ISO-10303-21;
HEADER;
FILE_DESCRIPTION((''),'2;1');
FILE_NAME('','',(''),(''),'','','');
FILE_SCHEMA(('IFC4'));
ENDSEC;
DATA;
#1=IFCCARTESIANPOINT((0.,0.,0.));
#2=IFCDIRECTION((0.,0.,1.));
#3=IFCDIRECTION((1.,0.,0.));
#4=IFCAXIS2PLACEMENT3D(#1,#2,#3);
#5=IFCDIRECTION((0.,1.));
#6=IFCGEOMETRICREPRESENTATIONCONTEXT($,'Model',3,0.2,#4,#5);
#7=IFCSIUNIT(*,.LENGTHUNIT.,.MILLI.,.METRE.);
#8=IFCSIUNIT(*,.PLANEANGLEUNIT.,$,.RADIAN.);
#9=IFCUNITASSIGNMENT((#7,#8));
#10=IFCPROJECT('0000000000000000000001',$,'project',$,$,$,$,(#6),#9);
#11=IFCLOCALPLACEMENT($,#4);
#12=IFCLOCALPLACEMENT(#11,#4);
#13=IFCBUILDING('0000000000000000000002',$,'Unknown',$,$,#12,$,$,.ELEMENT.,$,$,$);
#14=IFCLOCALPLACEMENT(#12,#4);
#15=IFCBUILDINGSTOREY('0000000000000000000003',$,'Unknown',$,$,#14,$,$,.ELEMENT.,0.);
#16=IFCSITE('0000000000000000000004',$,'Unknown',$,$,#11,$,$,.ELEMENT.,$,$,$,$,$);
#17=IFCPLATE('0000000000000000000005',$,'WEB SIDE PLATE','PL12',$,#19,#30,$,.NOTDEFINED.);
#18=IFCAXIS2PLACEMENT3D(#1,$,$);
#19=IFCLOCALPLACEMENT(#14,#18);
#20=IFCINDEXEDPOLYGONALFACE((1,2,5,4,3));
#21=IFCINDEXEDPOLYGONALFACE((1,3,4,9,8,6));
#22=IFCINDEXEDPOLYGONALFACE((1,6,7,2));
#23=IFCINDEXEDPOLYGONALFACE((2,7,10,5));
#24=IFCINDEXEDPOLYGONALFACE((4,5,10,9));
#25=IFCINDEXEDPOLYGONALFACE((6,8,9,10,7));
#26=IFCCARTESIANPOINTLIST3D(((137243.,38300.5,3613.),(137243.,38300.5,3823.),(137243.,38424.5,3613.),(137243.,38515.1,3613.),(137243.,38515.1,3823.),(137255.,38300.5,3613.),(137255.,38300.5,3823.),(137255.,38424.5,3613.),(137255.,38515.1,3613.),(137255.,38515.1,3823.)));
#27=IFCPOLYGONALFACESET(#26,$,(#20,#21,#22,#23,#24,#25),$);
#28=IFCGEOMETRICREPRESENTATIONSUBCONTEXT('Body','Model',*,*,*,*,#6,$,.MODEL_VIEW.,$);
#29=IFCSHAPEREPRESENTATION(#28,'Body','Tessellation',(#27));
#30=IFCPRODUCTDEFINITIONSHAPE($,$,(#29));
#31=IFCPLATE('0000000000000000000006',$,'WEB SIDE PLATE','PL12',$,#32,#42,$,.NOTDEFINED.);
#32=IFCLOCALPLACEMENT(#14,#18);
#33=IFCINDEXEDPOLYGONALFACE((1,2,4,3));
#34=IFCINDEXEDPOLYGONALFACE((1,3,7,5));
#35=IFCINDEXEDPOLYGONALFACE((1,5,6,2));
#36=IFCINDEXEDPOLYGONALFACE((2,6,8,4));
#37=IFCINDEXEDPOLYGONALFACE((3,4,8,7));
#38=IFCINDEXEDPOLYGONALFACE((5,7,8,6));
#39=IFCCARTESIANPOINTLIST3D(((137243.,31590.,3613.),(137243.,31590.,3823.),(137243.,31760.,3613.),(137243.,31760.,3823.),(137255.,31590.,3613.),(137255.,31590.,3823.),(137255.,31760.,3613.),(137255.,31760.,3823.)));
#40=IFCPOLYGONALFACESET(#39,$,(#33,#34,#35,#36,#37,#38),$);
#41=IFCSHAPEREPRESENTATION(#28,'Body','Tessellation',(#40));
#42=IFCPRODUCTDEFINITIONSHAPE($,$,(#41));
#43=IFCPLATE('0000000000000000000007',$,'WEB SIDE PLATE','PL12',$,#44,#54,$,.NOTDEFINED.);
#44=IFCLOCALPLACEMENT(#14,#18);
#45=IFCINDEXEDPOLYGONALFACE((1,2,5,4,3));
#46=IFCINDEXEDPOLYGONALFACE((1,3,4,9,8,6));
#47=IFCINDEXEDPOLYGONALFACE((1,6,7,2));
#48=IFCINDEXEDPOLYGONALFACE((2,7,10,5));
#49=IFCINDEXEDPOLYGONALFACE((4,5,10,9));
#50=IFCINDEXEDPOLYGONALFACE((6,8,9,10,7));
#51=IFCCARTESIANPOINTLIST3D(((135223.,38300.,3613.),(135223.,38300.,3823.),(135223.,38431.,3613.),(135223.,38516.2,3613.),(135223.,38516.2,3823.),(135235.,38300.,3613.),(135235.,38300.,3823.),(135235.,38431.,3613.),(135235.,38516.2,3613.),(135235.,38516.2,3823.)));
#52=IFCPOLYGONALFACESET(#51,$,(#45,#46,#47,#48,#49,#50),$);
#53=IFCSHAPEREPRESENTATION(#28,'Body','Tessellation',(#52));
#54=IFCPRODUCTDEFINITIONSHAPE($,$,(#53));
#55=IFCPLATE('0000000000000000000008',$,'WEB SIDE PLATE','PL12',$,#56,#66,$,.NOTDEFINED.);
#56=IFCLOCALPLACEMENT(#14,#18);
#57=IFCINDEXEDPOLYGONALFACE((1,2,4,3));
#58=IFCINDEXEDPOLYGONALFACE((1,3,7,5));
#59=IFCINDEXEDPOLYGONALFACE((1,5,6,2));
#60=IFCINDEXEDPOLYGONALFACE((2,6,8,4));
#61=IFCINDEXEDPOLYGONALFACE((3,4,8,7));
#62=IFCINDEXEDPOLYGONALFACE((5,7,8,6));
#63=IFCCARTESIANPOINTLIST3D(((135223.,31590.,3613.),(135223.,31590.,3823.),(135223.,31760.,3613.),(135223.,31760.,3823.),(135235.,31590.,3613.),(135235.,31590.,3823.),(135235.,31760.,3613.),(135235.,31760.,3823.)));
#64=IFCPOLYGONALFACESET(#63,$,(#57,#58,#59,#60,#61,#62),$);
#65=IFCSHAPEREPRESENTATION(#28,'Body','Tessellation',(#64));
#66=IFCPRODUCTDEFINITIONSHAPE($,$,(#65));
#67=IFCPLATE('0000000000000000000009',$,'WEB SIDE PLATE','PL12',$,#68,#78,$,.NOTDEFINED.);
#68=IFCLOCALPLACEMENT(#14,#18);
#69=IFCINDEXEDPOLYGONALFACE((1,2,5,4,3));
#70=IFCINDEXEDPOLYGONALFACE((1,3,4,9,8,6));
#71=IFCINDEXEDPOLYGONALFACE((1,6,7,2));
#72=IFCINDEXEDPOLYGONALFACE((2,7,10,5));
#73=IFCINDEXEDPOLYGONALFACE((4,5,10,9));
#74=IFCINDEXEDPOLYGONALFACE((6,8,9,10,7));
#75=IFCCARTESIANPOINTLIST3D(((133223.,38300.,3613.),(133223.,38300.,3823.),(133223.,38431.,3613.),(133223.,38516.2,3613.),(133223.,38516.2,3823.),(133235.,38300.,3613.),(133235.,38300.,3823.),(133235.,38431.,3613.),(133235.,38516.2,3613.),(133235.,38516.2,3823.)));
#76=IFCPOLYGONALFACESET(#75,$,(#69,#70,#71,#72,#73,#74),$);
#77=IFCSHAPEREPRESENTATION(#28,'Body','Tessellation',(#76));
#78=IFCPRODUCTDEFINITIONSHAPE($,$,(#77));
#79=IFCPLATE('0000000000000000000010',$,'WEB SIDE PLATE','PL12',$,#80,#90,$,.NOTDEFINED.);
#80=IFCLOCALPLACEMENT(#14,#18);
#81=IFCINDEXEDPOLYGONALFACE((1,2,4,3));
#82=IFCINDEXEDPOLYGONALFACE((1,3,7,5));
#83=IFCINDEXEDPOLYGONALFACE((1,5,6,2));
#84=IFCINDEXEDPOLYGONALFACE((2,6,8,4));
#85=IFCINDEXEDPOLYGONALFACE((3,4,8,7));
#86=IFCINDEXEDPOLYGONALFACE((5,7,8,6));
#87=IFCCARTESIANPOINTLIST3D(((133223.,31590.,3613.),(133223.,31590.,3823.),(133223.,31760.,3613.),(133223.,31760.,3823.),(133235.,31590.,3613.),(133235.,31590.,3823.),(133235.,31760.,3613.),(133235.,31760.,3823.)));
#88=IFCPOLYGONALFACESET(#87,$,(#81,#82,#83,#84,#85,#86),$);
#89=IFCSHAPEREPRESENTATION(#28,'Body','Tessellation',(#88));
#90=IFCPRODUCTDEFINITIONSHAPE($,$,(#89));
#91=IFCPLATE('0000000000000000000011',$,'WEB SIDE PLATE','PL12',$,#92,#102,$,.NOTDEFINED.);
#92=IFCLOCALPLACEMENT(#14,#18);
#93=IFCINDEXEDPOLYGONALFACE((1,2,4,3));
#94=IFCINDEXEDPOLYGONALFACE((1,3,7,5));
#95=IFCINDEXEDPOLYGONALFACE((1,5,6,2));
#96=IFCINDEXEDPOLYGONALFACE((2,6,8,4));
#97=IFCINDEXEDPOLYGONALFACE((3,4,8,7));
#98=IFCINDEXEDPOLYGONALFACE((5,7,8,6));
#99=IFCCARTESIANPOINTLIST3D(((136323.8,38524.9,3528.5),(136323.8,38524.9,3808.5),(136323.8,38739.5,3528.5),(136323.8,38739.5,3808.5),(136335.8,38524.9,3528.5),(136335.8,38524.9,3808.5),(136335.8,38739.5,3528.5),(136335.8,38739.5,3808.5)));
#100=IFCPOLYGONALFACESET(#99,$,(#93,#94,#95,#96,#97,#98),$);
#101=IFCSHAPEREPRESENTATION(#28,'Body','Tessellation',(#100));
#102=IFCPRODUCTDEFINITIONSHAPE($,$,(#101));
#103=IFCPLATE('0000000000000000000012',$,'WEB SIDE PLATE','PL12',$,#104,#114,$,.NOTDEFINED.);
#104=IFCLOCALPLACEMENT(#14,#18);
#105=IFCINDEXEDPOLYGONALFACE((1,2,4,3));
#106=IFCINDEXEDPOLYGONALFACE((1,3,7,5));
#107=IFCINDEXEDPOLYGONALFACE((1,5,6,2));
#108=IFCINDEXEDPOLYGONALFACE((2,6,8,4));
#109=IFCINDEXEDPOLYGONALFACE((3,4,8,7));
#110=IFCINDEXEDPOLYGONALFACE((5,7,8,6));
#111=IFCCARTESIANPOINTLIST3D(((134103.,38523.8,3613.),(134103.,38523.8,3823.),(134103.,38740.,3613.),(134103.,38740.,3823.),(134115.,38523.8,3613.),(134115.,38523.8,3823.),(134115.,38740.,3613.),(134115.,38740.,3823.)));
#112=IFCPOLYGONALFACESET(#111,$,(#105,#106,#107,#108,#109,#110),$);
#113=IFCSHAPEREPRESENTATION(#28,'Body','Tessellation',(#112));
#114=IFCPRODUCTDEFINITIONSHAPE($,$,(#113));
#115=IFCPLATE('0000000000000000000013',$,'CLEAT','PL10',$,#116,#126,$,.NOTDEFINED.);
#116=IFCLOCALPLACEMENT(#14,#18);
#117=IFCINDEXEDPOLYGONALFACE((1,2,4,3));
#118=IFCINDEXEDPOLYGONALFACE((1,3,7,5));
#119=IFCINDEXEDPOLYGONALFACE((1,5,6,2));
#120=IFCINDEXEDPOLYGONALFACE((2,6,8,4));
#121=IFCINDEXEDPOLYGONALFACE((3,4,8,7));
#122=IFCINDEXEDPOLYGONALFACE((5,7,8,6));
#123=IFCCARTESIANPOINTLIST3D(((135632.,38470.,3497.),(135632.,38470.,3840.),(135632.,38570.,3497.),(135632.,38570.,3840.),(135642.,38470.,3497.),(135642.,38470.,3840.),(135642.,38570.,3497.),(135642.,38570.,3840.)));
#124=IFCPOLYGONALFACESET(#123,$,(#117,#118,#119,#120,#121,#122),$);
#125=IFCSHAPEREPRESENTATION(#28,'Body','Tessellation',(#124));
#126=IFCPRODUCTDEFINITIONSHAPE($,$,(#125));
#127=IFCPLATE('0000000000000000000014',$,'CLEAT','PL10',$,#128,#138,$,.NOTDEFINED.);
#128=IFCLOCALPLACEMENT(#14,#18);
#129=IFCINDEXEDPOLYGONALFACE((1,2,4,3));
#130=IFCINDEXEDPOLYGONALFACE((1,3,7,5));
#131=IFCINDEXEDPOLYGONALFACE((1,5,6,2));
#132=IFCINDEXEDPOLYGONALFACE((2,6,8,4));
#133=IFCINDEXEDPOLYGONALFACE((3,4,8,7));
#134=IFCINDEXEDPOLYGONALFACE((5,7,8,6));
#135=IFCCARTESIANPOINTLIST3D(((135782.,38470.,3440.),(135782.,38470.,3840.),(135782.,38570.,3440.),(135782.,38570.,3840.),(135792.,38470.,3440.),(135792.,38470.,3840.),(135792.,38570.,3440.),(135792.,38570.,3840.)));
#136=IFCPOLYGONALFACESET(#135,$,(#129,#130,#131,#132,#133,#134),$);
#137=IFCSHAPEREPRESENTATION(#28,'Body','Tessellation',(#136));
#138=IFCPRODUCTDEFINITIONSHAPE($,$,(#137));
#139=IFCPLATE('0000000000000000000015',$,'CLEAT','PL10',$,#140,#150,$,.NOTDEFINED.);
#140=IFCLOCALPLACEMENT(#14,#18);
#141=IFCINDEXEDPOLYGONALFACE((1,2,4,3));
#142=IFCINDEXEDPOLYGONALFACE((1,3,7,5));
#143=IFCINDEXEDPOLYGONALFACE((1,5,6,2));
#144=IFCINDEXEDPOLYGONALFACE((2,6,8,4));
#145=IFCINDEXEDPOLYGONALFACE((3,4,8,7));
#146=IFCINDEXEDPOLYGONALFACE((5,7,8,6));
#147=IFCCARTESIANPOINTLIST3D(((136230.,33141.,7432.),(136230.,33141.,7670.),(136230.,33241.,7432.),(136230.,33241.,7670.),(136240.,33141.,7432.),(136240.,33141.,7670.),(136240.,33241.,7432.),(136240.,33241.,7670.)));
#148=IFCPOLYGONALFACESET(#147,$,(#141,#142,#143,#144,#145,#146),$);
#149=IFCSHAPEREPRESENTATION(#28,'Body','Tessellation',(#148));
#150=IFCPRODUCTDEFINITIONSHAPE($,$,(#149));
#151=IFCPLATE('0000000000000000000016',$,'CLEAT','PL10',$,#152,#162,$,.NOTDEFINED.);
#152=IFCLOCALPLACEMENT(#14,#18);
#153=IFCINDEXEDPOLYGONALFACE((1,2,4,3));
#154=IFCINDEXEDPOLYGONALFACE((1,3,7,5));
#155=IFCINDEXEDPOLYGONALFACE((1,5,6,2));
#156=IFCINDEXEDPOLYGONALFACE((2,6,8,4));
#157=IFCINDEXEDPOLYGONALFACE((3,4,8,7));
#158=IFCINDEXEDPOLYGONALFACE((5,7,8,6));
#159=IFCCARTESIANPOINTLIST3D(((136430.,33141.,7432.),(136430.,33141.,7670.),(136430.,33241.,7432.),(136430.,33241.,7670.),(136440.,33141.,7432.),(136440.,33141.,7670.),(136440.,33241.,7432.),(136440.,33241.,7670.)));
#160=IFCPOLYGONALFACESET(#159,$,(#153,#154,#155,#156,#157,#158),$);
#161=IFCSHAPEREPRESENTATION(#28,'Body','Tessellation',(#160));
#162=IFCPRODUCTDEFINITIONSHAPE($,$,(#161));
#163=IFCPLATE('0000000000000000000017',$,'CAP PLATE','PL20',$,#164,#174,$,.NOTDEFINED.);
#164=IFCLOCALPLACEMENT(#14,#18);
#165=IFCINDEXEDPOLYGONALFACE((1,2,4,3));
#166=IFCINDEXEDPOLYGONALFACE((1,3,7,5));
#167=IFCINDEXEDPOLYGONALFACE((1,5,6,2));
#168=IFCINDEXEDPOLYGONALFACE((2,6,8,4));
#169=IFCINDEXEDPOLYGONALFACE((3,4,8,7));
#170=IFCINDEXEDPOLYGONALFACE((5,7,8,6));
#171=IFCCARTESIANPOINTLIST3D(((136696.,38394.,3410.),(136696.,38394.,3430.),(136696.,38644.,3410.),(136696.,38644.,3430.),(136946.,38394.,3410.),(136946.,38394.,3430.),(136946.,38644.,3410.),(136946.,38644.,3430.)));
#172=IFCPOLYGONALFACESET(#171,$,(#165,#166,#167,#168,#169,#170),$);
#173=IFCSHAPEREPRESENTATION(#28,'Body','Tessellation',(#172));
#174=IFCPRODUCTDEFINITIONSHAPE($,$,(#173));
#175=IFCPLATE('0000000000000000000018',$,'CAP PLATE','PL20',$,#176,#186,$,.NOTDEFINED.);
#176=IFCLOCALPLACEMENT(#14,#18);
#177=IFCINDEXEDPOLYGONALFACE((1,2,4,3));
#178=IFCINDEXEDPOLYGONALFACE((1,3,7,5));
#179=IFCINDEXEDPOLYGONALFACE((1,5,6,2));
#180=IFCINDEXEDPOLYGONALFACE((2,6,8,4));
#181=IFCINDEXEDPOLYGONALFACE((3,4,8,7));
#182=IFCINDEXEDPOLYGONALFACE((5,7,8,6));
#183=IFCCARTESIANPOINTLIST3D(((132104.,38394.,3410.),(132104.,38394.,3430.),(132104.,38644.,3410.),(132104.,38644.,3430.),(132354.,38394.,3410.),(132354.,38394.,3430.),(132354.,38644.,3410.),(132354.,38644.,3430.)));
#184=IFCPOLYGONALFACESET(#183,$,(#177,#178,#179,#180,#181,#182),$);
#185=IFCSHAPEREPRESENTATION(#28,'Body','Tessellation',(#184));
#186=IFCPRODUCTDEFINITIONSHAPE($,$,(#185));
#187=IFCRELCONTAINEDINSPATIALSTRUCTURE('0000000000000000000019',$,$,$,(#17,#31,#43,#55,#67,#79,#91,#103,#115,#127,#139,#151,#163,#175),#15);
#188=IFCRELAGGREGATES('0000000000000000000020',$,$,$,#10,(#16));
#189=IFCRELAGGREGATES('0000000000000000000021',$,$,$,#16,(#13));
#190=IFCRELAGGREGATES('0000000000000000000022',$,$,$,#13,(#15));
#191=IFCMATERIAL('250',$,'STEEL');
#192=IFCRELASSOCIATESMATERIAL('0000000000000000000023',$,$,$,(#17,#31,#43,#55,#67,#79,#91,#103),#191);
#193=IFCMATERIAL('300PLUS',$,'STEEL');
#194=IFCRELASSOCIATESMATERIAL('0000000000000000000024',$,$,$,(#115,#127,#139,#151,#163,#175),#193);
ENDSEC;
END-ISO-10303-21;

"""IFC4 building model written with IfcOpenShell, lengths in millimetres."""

from ifc_helpers import new_model, si_unit, direction, frame, origin_with_axes, place, context, subcontext, project, spatial, line, indexed_curve, outline, extrude, material, element, save


model = new_model("IFC4")

# Units and contexts
model_context = context("Model", 3, precision=0.2, world=origin_with_axes(), true_north=direction((0.0, 1.0)))
body_context = subcontext(model_context, "Body", "Model", "MODEL_VIEW")
ifc_project = project(units=[si_unit("LENGTHUNIT", "METRE", prefix="MILLI"), si_unit("PLANEANGLEUNIT", "RADIAN")], contexts=[model_context])

# Site, building, storey
site_placement = place(None, origin_with_axes())
site = spatial("IfcSite", under=ifc_project, at=site_placement, Name="Unknown", CompositionType="ELEMENT")
building_placement = place(site_placement, origin_with_axes())
building = spatial("IfcBuilding", under=site, at=building_placement, Name="Unknown", CompositionType="ELEMENT")
storey_placement = place(building_placement, origin_with_axes())
storey = spatial("IfcBuildingStorey", under=building, at=storey_placement, Name="Unknown", CompositionType="ELEMENT", Elevation=0.0)

# Shared definitions
ifc_material_1 = material(Name="300PLUS", Category="STEEL")

# Plates
ifc_material_2 = material(Name="250", Category="STEEL")
plate_1_placement = place(storey_placement, frame((137249.0, 38424.5, 3613.0), z_axis=(1.0, 0.0, 0.0), x_axis=(0.0, 1.0, 0.0)))
element("IfcPlate", 1, at=plate_1_placement, inside=storey, material=ifc_material_2, Name="WEB SIDE PLATE", Description="PL12", PredefinedType="NOTDEFINED", context=body_context, shape_type="SolidModel", body=[
    extrude(outline(indexed_curve([(0.0, 0.0), (90.6, 0.0), (90.6, 210.0), (-124.0, 210.0), (-124.0, 0.0)], segments=[line(1, 2, 3, 4, 5, 1)])), frame((0.0, 0.0, 6.0), z_axis=(0.0, 0.0, 1.0), x_axis=(1.0, 0.0, 0.0)), (0.0, 0.0, -1.0), 12.0),
])
plate_2_placement = place(storey_placement, frame((137249.0, 31590.0, 3613.0), z_axis=(1.0, 0.0, 0.0), x_axis=(0.0, 1.0, 0.0)))
element("IfcPlate", 2, at=plate_2_placement, inside=storey, material=ifc_material_2, Name="WEB SIDE PLATE", Description="PL12", PredefinedType="NOTDEFINED", context=body_context, shape_type="SolidModel", body=[
    extrude(outline(indexed_curve([(0.0, 0.0), (170.0, 0.0), (170.0, 210.0), (0.0, 210.0)], segments=[line(1, 2, 3, 4, 1)])), frame((0.0, 0.0, 6.0), z_axis=(0.0, 0.0, 1.0), x_axis=(1.0, 0.0, 0.0)), (0.0, 0.0, -1.0), 12.0),
])
plate_3_placement = place(storey_placement, frame((135229.0, 38431.0, 3613.0), z_axis=(1.0, 0.0, 0.0), x_axis=(0.0, 1.0, 0.0)))
element("IfcPlate", 3, at=plate_3_placement, inside=storey, material=ifc_material_2, Name="WEB SIDE PLATE", Description="PL12", PredefinedType="NOTDEFINED", context=body_context, shape_type="SolidModel", body=[
    extrude(outline(indexed_curve([(0.0, 0.0), (85.2, 0.0), (85.2, 210.0), (-131.0, 210.0), (-131.0, 0.0)], segments=[line(1, 2, 3, 4, 5, 1)])), frame((0.0, 0.0, 6.0), z_axis=(0.0, 0.0, 1.0), x_axis=(1.0, 0.0, 0.0)), (0.0, 0.0, -1.0), 12.0),
])
plate_4_placement = place(storey_placement, frame((135229.0, 31590.0, 3613.0), z_axis=(1.0, 0.0, 0.0), x_axis=(0.0, 1.0, 0.0)))
element("IfcPlate", 4, at=plate_4_placement, inside=storey, material=ifc_material_2, Name="WEB SIDE PLATE", Description="PL12", PredefinedType="NOTDEFINED", context=body_context, shape_type="SolidModel", body=[
    extrude(outline(indexed_curve([(0.0, 0.0), (170.0, 0.0), (170.0, 210.0), (0.0, 210.0)], segments=[line(1, 2, 3, 4, 1)])), frame((0.0, 0.0, 6.0), z_axis=(0.0, 0.0, 1.0), x_axis=(1.0, 0.0, 0.0)), (0.0, 0.0, -1.0), 12.0),
])
plate_5_placement = place(storey_placement, frame((133229.0, 38431.0, 3613.0), z_axis=(1.0, 0.0, 0.0), x_axis=(0.0, 1.0, 0.0)))
element("IfcPlate", 5, at=plate_5_placement, inside=storey, material=ifc_material_2, Name="WEB SIDE PLATE", Description="PL12", PredefinedType="NOTDEFINED", context=body_context, shape_type="SolidModel", body=[
    extrude(outline(indexed_curve([(0.0, 0.0), (85.2, 0.0), (85.2, 210.0), (-131.0, 210.0), (-131.0, 0.0)], segments=[line(1, 2, 3, 4, 5, 1)])), frame((0.0, 0.0, 6.0), z_axis=(0.0, 0.0, 1.0), x_axis=(1.0, 0.0, 0.0)), (0.0, 0.0, -1.0), 12.0),
])
plate_6_placement = place(storey_placement, frame((133229.0, 31590.0, 3613.0), z_axis=(1.0, 0.0, 0.0), x_axis=(0.0, 1.0, 0.0)))
element("IfcPlate", 6, at=plate_6_placement, inside=storey, material=ifc_material_2, Name="WEB SIDE PLATE", Description="PL12", PredefinedType="NOTDEFINED", context=body_context, shape_type="SolidModel", body=[
    extrude(outline(indexed_curve([(0.0, 0.0), (170.0, 0.0), (170.0, 210.0), (0.0, 210.0)], segments=[line(1, 2, 3, 4, 1)])), frame((0.0, 0.0, 6.0), z_axis=(0.0, 0.0, 1.0), x_axis=(1.0, 0.0, 0.0)), (0.0, 0.0, -1.0), 12.0),
])
plate_7_placement = place(storey_placement, frame((136329.8, 38739.5, 3528.5), z_axis=(1.0, 0.0, 0.0), x_axis=(0.0, 0.0, 1.0)))
element("IfcPlate", 7, at=plate_7_placement, inside=storey, material=ifc_material_2, Name="WEB SIDE PLATE", Description="PL12", PredefinedType="NOTDEFINED", context=body_context, shape_type="SolidModel", body=[
    extrude(outline(indexed_curve([(0.0, 0.0), (280.0, 0.0), (280.0, 214.6), (0.0, 214.6)], segments=[line(1, 2, 3, 4, 1)])), frame((0.0, 0.0, 6.0), z_axis=(0.0, 0.0, 1.0), x_axis=(1.0, 0.0, 0.0)), (0.0, 0.0, -1.0), 12.0),
])
plate_8_placement = place(storey_placement, frame((134109.0, 38740.0, 3613.0), z_axis=(1.0, 0.0, 0.0), x_axis=(0.0, 0.0, 1.0)))
element("IfcPlate", 8, at=plate_8_placement, inside=storey, material=ifc_material_2, Name="WEB SIDE PLATE", Description="PL12", PredefinedType="NOTDEFINED", context=body_context, shape_type="SolidModel", body=[
    extrude(outline(indexed_curve([(0.0, 0.0), (210.0, 0.0), (210.0, 216.2), (0.0, 216.2)], segments=[line(1, 2, 3, 4, 1)])), frame((0.0, 0.0, 6.0), z_axis=(0.0, 0.0, 1.0), x_axis=(1.0, 0.0, 0.0)), (0.0, 0.0, -1.0), 12.0),
])
plate_9_placement = place(storey_placement, frame((135637.0, 38470.0, 3497.0), z_axis=(1.0, 0.0, 0.0), x_axis=(0.0, 1.0, 0.0)))
element("IfcPlate", 9, at=plate_9_placement, inside=storey, material=ifc_material_1, Name="CLEAT", Description="PL10", PredefinedType="NOTDEFINED", context=body_context, shape_type="SolidModel", body=[
    extrude(outline(indexed_curve([(0.0, 0.0), (100.0, 0.0), (100.0, 343.0), (0.0, 343.0)], segments=[line(1, 2, 3, 4, 1)])), frame((0.0, 0.0, 5.0), z_axis=(0.0, 0.0, 1.0), x_axis=(1.0, 0.0, 0.0)), (0.0, 0.0, -1.0), 10.0),
])
plate_10_placement = place(storey_placement, frame((135787.0, 38470.0, 3440.0), z_axis=(1.0, 0.0, 0.0), x_axis=(0.0, 1.0, 0.0)))
element("IfcPlate", 10, at=plate_10_placement, inside=storey, material=ifc_material_1, Name="CLEAT", Description="PL10", PredefinedType="NOTDEFINED", context=body_context, shape_type="SolidModel", body=[
    extrude(outline(indexed_curve([(0.0, 0.0), (100.0, 0.0), (100.0, 400.0), (0.0, 400.0)], segments=[line(1, 2, 3, 4, 1)])), frame((0.0, 0.0, 5.0), z_axis=(0.0, 0.0, 1.0), x_axis=(1.0, 0.0, 0.0)), (0.0, 0.0, -1.0), 10.0),
])
for number, where, z_axis, x_axis, name in (
    (11, (136235.0, 33141.0, 7432.0), (1.0, 0.0, 0.0), (0.0, 1.0, 0.0), "CLEAT"),
    (12, (136435.0, 33141.0, 7432.0), (1.0, 0.0, 0.0), (0.0, 1.0, 0.0), "CLEAT"),
):
    element("IfcPlate", number, at=place(storey_placement, frame(where, z_axis=z_axis, x_axis=x_axis)), inside=storey, material=ifc_material_1, Name=name, Description="PL10", PredefinedType="NOTDEFINED", context=body_context, shape_type="SolidModel", body=[
        extrude(outline(indexed_curve([(0.0, 0.0), (100.0, 0.0), (100.0, 238.0), (0.0, 238.0)], segments=[line(1, 2, 3, 4, 1)])), frame((0.0, 0.0, 5.0), z_axis=(0.0, 0.0, 1.0), x_axis=(1.0, 0.0, 0.0)), (0.0, 0.0, -1.0), 10.0),
    ])
for number, where, z_axis, x_axis, name in (
    (13, (136696.0, 38394.0, 3420.0), (0.0, 0.0, 1.0), (1.0, 0.0, 0.0), "CAP PLATE"),
    (14, (132104.0, 38394.0, 3420.0), (0.0, 0.0, 1.0), (1.0, 0.0, 0.0), "CAP PLATE"),
):
    element("IfcPlate", number, at=place(storey_placement, frame(where, z_axis=z_axis, x_axis=x_axis)), inside=storey, material=ifc_material_1, Name=name, Description="PL20", PredefinedType="NOTDEFINED", context=body_context, shape_type="SolidModel", body=[
        extrude(outline(indexed_curve([(0.0, 0.0), (250.0, 0.0), (250.0, 250.0), (0.0, 250.0)], segments=[line(1, 2, 3, 4, 1)])), frame((0.0, 0.0, 10.0), z_axis=(0.0, 0.0, 1.0), x_axis=(1.0, 0.0, 0.0)), (0.0, 0.0, -1.0), 20.0),
    ])

save(model, "model.ifc")
